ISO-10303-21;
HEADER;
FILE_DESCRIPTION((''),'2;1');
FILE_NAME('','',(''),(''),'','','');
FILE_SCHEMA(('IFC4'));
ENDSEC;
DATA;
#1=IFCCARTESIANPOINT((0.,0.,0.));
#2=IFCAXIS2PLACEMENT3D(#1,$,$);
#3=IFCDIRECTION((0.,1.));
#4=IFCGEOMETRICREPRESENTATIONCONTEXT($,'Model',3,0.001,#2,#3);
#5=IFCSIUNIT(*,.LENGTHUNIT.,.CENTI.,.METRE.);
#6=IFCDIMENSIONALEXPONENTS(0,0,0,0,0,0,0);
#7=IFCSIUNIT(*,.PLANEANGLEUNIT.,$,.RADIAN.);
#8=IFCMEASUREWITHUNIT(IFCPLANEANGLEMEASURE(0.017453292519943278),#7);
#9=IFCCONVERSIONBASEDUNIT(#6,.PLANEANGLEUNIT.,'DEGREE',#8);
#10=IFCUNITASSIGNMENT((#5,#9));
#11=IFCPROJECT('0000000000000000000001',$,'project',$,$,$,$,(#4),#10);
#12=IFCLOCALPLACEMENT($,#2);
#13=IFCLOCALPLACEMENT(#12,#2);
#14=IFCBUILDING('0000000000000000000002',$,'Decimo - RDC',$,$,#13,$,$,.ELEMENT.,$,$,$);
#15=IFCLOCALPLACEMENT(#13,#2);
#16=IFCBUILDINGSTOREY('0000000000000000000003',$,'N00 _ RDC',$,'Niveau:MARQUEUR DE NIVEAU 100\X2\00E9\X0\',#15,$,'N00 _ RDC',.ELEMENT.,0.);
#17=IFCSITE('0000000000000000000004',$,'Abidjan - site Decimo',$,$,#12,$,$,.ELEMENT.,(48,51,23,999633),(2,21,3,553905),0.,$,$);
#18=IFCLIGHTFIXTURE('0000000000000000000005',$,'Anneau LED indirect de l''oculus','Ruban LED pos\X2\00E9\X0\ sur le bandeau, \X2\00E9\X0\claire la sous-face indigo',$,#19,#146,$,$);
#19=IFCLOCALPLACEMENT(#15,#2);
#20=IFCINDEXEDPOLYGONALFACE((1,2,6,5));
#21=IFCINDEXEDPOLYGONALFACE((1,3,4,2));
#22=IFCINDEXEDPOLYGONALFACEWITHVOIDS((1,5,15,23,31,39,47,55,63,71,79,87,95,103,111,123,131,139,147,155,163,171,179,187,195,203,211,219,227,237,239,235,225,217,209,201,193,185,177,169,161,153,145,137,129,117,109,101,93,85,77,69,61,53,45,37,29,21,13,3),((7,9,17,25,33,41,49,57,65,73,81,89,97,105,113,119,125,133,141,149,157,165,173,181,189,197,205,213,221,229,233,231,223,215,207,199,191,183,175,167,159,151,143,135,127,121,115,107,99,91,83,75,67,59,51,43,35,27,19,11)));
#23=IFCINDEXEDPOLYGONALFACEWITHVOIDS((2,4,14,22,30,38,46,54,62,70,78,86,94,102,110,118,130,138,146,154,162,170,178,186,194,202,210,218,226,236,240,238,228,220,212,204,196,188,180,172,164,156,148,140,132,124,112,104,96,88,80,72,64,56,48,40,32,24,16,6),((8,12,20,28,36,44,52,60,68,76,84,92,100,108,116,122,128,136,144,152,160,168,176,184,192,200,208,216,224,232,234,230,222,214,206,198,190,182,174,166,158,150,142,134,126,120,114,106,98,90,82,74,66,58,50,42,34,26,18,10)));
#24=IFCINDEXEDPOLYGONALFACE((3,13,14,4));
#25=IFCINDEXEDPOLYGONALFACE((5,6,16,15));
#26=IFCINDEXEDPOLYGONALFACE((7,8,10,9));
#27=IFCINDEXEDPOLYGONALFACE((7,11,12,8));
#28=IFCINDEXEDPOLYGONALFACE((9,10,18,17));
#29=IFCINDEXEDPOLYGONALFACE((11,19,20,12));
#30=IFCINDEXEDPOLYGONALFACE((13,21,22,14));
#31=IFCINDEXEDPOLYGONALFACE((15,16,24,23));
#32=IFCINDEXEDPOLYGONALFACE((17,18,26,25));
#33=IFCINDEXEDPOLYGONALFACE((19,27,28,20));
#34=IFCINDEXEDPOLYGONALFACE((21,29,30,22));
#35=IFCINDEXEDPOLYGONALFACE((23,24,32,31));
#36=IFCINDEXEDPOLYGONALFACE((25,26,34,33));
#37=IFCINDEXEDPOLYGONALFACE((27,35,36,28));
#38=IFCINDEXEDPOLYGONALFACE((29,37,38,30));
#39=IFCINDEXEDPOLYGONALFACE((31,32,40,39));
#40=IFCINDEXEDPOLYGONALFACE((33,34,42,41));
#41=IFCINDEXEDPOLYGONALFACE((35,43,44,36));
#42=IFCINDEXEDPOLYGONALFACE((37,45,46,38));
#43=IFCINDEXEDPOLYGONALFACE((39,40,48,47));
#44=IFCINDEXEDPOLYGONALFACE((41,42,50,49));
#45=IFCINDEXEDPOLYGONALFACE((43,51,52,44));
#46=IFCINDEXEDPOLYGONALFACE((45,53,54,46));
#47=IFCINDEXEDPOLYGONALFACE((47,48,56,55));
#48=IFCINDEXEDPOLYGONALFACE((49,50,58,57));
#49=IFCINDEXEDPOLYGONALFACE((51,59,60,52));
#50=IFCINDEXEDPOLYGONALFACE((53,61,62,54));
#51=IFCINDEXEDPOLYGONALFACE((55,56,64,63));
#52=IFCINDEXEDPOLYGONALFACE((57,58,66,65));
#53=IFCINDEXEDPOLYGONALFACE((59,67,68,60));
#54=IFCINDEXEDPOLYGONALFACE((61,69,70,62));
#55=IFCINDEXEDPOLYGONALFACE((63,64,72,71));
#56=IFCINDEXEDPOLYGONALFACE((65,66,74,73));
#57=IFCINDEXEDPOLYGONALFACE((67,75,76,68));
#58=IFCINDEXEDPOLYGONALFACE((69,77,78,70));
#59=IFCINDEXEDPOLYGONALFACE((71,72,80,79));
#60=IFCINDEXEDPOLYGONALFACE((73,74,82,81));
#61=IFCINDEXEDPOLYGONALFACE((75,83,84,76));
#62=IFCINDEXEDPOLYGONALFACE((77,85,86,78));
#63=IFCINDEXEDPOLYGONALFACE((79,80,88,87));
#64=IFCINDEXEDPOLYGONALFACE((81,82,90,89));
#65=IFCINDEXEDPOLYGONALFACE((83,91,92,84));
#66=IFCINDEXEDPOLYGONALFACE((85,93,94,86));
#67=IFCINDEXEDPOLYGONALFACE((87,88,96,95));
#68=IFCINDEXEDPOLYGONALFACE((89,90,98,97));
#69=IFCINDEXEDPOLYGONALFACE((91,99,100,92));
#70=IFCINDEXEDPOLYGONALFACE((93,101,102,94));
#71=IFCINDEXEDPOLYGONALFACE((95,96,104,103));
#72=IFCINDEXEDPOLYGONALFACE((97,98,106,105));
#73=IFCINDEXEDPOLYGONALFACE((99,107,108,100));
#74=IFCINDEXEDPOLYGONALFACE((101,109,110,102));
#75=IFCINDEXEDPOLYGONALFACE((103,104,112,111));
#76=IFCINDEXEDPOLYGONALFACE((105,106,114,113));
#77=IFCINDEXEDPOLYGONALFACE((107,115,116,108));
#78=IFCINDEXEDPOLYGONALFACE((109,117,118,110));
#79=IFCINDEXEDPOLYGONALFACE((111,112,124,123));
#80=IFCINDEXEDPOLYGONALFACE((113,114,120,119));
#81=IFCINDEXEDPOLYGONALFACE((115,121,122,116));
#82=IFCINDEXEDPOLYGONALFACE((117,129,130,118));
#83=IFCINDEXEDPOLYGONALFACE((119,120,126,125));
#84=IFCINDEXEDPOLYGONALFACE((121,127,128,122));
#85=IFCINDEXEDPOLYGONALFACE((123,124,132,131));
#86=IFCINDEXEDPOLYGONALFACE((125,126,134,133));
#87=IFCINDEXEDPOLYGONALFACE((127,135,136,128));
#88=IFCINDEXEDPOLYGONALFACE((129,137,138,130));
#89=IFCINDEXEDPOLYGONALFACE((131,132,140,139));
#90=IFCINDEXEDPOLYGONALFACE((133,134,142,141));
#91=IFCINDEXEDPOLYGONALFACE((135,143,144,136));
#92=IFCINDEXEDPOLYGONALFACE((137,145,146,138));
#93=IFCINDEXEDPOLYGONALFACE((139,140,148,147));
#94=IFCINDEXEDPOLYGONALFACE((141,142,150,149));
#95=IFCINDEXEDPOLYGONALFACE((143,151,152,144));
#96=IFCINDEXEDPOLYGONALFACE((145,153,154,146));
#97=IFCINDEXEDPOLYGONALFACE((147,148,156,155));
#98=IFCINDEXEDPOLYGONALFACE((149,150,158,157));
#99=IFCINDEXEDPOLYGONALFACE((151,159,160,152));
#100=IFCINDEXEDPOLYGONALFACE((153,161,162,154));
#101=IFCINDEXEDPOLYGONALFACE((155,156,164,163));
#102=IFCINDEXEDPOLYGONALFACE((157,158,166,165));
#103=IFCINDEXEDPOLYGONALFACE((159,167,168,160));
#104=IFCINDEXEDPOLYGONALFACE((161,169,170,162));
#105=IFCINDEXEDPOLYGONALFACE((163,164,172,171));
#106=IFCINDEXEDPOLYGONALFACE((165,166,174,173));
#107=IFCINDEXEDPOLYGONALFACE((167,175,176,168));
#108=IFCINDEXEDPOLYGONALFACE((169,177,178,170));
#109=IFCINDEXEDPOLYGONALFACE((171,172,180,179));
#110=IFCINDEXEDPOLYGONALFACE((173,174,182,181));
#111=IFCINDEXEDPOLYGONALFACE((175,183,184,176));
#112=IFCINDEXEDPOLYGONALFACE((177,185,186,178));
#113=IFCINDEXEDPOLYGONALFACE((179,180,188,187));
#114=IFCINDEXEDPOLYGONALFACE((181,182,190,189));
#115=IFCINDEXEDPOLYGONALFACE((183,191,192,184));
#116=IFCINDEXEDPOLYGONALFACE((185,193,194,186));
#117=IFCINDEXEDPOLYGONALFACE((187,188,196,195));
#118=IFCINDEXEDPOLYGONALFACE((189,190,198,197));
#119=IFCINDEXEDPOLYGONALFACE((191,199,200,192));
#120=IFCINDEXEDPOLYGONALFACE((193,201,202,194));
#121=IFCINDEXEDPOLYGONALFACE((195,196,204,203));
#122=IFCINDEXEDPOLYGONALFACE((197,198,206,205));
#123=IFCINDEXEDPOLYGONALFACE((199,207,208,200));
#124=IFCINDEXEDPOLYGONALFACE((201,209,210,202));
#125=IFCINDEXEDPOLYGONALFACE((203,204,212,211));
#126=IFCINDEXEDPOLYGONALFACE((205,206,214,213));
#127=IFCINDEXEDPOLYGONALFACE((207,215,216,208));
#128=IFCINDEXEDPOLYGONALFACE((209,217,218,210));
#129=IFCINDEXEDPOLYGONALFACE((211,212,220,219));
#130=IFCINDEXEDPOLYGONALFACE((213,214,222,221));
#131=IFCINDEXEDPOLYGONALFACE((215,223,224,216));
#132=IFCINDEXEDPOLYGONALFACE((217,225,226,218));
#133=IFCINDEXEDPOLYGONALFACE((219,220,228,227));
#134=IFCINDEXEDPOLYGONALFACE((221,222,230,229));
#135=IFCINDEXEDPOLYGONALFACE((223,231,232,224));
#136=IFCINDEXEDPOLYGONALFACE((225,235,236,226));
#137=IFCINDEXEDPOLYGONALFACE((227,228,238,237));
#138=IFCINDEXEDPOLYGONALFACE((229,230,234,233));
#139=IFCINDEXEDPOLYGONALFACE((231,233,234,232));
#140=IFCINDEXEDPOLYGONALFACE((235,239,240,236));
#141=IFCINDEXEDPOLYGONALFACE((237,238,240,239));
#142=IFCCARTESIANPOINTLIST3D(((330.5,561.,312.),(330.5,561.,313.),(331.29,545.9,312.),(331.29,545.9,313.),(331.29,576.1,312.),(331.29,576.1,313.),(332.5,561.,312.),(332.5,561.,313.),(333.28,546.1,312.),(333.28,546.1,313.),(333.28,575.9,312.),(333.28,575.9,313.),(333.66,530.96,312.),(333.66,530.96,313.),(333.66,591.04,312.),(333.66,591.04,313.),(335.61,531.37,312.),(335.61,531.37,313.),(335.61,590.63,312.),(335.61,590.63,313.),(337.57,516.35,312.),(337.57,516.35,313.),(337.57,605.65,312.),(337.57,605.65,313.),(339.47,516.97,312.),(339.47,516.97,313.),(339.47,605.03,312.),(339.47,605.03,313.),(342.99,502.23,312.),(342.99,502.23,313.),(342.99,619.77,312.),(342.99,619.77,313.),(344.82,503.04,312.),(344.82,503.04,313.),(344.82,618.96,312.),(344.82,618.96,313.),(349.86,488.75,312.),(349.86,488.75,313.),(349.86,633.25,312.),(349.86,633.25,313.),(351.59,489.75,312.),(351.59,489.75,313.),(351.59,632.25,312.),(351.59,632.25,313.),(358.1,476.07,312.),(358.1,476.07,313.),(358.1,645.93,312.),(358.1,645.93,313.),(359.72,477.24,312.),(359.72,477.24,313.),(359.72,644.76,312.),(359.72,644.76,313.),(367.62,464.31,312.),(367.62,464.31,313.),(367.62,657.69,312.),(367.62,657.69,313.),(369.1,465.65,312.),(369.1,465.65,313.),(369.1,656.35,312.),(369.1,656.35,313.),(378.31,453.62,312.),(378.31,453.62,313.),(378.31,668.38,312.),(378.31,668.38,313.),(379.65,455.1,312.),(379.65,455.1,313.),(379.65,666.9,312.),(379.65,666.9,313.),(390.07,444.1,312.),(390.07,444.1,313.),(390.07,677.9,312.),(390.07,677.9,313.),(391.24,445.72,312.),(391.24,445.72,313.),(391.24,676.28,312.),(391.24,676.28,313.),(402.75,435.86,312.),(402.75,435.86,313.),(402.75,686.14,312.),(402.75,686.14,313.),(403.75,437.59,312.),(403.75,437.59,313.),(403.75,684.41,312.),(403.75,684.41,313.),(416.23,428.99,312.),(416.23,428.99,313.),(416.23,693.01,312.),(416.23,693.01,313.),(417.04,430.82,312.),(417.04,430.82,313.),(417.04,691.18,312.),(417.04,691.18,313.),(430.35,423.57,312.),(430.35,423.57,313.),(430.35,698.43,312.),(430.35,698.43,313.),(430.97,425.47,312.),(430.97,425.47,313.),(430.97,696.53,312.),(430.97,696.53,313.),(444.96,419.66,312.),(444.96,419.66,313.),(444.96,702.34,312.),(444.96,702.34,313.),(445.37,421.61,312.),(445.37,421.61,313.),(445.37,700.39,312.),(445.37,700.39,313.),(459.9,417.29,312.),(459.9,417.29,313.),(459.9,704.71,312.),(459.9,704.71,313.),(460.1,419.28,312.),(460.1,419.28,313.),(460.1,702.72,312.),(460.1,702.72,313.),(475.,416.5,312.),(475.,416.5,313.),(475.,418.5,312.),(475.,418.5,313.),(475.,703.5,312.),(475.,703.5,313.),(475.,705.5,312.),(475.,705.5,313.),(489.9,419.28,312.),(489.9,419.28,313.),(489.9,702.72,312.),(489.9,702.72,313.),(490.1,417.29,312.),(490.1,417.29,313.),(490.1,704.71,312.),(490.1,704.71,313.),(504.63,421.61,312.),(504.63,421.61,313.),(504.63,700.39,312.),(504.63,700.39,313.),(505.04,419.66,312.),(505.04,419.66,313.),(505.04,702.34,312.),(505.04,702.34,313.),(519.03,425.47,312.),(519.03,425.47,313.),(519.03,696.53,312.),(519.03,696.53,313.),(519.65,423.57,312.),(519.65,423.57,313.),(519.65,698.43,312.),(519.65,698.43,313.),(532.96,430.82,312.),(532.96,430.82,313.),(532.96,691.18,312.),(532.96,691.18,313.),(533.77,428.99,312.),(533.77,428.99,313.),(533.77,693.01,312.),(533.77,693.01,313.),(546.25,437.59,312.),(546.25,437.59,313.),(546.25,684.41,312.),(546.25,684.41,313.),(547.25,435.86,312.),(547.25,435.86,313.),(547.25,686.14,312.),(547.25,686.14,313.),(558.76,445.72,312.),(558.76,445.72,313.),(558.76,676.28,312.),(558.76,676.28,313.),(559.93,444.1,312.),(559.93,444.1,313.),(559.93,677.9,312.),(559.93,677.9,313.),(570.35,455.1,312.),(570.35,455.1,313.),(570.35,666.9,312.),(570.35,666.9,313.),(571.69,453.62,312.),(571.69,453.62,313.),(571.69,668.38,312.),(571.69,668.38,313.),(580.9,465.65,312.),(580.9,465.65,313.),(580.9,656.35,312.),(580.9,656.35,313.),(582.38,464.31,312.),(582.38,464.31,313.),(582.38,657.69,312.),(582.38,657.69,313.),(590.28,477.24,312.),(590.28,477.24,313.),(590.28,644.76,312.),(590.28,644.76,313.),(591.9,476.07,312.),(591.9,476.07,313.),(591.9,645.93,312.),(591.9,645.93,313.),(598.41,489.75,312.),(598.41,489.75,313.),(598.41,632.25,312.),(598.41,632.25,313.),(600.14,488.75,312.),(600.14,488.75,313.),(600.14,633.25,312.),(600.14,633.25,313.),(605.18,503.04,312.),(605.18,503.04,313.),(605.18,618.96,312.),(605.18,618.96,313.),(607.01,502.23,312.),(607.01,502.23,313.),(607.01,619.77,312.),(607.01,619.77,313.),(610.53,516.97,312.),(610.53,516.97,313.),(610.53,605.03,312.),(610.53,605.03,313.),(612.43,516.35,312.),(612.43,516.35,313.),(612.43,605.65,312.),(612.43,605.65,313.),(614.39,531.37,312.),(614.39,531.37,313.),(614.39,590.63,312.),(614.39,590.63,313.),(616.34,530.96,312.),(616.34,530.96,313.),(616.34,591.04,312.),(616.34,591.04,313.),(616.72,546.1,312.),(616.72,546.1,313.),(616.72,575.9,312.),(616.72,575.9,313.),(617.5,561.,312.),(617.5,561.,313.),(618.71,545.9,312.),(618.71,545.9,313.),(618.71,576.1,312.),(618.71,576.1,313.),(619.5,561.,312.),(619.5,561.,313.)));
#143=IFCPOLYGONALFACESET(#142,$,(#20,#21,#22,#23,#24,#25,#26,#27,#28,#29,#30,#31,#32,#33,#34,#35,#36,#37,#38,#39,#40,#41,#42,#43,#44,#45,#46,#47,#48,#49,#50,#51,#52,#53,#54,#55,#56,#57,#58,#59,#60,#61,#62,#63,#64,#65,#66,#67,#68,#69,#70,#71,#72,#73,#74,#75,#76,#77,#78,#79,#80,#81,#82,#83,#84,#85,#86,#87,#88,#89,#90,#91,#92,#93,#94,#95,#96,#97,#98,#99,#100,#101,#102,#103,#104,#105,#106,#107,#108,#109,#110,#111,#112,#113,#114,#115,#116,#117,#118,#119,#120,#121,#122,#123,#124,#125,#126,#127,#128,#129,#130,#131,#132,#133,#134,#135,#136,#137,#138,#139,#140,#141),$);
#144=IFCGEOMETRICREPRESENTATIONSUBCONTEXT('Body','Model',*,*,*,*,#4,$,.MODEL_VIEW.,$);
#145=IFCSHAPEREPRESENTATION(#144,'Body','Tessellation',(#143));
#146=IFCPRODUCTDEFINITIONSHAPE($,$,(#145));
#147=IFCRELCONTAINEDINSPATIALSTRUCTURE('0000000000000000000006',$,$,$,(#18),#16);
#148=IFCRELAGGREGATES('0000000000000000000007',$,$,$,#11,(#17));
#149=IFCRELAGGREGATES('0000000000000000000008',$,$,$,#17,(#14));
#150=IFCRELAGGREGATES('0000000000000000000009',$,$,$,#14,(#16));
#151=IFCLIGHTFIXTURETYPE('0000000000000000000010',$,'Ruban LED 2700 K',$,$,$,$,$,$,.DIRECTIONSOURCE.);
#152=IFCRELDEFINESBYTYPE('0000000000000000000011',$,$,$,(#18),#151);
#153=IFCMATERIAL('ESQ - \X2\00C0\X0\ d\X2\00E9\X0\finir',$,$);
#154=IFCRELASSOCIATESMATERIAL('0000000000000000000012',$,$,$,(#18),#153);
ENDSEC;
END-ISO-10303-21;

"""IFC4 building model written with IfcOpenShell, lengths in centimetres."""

from ifc_helpers import new_model, entity, si_unit, converted_unit, direction, frame, frame_2d, origin, origin_with_axes, place, context, subcontext, project, spatial, hollow_circle, extrude, material, type_object, element, save


model = new_model("IFC4")

# Units and contexts
model_context = context("Model", 3, precision=0.001, world=origin(), true_north=direction((0.0, 1.0)))
body_context = subcontext(model_context, "Body", "Model", "MODEL_VIEW")
ifc_project = project(units=[si_unit("LENGTHUNIT", "METRE", prefix="CENTI"), converted_unit("PLANEANGLEUNIT", "DEGREE", entity("IfcPlaneAngleMeasure", 0.017453292519943278), si_unit("PLANEANGLEUNIT", "RADIAN"), dimensions=[0, 0, 0, 0, 0, 0, 0])], contexts=[model_context])

# Site, building, storey
site_placement = place(None, origin())
site = spatial("IfcSite", under=ifc_project, at=site_placement, Name="Abidjan - site Decimo", CompositionType="ELEMENT", RefLatitude=(48, 51, 23, 999633), RefLongitude=(2, 21, 3, 553905), RefElevation=0.0)
building_placement = place(site_placement, origin())
building = spatial("IfcBuilding", under=site, at=building_placement, Name="Decimo - RDC", CompositionType="ELEMENT")
storey_placement = place(building_placement, origin())
storey = spatial("IfcBuildingStorey", under=building, at=storey_placement, Name="N00 _ RDC", ObjectType="Niveau:MARQUEUR DE NIVEAU 100é", LongName="N00 _ RDC", CompositionType="ELEMENT", Elevation=0.0)

# Light fixture
ifc_material_1 = material(Name="ESQ - À définir")
light_fixture_type_1 = type_object("IfcLightFixtureType", Name="Ruban LED 2700 K", PredefinedType="DIRECTIONSOURCE")
light_fixture_1_placement = place(storey_placement, origin_with_axes())
element("IfcLightFixture", 1, at=light_fixture_1_placement, inside=storey, type_object=light_fixture_type_1, material=ifc_material_1, Name="Anneau LED indirect de l'oculus", Description="Ruban LED posé sur le bandeau, éclaire la sous-face indigo", context=body_context, shape_type="SweptSolid", body=[
    extrude(hollow_circle(Radius=144.5, WallThickness=2.0, at=frame_2d((475.0, 561.0))), frame((0.0, 0.0, 312.0)), (0.0, 0.0, 1.0), 1.0),
])

save(model, "model.ifc")
